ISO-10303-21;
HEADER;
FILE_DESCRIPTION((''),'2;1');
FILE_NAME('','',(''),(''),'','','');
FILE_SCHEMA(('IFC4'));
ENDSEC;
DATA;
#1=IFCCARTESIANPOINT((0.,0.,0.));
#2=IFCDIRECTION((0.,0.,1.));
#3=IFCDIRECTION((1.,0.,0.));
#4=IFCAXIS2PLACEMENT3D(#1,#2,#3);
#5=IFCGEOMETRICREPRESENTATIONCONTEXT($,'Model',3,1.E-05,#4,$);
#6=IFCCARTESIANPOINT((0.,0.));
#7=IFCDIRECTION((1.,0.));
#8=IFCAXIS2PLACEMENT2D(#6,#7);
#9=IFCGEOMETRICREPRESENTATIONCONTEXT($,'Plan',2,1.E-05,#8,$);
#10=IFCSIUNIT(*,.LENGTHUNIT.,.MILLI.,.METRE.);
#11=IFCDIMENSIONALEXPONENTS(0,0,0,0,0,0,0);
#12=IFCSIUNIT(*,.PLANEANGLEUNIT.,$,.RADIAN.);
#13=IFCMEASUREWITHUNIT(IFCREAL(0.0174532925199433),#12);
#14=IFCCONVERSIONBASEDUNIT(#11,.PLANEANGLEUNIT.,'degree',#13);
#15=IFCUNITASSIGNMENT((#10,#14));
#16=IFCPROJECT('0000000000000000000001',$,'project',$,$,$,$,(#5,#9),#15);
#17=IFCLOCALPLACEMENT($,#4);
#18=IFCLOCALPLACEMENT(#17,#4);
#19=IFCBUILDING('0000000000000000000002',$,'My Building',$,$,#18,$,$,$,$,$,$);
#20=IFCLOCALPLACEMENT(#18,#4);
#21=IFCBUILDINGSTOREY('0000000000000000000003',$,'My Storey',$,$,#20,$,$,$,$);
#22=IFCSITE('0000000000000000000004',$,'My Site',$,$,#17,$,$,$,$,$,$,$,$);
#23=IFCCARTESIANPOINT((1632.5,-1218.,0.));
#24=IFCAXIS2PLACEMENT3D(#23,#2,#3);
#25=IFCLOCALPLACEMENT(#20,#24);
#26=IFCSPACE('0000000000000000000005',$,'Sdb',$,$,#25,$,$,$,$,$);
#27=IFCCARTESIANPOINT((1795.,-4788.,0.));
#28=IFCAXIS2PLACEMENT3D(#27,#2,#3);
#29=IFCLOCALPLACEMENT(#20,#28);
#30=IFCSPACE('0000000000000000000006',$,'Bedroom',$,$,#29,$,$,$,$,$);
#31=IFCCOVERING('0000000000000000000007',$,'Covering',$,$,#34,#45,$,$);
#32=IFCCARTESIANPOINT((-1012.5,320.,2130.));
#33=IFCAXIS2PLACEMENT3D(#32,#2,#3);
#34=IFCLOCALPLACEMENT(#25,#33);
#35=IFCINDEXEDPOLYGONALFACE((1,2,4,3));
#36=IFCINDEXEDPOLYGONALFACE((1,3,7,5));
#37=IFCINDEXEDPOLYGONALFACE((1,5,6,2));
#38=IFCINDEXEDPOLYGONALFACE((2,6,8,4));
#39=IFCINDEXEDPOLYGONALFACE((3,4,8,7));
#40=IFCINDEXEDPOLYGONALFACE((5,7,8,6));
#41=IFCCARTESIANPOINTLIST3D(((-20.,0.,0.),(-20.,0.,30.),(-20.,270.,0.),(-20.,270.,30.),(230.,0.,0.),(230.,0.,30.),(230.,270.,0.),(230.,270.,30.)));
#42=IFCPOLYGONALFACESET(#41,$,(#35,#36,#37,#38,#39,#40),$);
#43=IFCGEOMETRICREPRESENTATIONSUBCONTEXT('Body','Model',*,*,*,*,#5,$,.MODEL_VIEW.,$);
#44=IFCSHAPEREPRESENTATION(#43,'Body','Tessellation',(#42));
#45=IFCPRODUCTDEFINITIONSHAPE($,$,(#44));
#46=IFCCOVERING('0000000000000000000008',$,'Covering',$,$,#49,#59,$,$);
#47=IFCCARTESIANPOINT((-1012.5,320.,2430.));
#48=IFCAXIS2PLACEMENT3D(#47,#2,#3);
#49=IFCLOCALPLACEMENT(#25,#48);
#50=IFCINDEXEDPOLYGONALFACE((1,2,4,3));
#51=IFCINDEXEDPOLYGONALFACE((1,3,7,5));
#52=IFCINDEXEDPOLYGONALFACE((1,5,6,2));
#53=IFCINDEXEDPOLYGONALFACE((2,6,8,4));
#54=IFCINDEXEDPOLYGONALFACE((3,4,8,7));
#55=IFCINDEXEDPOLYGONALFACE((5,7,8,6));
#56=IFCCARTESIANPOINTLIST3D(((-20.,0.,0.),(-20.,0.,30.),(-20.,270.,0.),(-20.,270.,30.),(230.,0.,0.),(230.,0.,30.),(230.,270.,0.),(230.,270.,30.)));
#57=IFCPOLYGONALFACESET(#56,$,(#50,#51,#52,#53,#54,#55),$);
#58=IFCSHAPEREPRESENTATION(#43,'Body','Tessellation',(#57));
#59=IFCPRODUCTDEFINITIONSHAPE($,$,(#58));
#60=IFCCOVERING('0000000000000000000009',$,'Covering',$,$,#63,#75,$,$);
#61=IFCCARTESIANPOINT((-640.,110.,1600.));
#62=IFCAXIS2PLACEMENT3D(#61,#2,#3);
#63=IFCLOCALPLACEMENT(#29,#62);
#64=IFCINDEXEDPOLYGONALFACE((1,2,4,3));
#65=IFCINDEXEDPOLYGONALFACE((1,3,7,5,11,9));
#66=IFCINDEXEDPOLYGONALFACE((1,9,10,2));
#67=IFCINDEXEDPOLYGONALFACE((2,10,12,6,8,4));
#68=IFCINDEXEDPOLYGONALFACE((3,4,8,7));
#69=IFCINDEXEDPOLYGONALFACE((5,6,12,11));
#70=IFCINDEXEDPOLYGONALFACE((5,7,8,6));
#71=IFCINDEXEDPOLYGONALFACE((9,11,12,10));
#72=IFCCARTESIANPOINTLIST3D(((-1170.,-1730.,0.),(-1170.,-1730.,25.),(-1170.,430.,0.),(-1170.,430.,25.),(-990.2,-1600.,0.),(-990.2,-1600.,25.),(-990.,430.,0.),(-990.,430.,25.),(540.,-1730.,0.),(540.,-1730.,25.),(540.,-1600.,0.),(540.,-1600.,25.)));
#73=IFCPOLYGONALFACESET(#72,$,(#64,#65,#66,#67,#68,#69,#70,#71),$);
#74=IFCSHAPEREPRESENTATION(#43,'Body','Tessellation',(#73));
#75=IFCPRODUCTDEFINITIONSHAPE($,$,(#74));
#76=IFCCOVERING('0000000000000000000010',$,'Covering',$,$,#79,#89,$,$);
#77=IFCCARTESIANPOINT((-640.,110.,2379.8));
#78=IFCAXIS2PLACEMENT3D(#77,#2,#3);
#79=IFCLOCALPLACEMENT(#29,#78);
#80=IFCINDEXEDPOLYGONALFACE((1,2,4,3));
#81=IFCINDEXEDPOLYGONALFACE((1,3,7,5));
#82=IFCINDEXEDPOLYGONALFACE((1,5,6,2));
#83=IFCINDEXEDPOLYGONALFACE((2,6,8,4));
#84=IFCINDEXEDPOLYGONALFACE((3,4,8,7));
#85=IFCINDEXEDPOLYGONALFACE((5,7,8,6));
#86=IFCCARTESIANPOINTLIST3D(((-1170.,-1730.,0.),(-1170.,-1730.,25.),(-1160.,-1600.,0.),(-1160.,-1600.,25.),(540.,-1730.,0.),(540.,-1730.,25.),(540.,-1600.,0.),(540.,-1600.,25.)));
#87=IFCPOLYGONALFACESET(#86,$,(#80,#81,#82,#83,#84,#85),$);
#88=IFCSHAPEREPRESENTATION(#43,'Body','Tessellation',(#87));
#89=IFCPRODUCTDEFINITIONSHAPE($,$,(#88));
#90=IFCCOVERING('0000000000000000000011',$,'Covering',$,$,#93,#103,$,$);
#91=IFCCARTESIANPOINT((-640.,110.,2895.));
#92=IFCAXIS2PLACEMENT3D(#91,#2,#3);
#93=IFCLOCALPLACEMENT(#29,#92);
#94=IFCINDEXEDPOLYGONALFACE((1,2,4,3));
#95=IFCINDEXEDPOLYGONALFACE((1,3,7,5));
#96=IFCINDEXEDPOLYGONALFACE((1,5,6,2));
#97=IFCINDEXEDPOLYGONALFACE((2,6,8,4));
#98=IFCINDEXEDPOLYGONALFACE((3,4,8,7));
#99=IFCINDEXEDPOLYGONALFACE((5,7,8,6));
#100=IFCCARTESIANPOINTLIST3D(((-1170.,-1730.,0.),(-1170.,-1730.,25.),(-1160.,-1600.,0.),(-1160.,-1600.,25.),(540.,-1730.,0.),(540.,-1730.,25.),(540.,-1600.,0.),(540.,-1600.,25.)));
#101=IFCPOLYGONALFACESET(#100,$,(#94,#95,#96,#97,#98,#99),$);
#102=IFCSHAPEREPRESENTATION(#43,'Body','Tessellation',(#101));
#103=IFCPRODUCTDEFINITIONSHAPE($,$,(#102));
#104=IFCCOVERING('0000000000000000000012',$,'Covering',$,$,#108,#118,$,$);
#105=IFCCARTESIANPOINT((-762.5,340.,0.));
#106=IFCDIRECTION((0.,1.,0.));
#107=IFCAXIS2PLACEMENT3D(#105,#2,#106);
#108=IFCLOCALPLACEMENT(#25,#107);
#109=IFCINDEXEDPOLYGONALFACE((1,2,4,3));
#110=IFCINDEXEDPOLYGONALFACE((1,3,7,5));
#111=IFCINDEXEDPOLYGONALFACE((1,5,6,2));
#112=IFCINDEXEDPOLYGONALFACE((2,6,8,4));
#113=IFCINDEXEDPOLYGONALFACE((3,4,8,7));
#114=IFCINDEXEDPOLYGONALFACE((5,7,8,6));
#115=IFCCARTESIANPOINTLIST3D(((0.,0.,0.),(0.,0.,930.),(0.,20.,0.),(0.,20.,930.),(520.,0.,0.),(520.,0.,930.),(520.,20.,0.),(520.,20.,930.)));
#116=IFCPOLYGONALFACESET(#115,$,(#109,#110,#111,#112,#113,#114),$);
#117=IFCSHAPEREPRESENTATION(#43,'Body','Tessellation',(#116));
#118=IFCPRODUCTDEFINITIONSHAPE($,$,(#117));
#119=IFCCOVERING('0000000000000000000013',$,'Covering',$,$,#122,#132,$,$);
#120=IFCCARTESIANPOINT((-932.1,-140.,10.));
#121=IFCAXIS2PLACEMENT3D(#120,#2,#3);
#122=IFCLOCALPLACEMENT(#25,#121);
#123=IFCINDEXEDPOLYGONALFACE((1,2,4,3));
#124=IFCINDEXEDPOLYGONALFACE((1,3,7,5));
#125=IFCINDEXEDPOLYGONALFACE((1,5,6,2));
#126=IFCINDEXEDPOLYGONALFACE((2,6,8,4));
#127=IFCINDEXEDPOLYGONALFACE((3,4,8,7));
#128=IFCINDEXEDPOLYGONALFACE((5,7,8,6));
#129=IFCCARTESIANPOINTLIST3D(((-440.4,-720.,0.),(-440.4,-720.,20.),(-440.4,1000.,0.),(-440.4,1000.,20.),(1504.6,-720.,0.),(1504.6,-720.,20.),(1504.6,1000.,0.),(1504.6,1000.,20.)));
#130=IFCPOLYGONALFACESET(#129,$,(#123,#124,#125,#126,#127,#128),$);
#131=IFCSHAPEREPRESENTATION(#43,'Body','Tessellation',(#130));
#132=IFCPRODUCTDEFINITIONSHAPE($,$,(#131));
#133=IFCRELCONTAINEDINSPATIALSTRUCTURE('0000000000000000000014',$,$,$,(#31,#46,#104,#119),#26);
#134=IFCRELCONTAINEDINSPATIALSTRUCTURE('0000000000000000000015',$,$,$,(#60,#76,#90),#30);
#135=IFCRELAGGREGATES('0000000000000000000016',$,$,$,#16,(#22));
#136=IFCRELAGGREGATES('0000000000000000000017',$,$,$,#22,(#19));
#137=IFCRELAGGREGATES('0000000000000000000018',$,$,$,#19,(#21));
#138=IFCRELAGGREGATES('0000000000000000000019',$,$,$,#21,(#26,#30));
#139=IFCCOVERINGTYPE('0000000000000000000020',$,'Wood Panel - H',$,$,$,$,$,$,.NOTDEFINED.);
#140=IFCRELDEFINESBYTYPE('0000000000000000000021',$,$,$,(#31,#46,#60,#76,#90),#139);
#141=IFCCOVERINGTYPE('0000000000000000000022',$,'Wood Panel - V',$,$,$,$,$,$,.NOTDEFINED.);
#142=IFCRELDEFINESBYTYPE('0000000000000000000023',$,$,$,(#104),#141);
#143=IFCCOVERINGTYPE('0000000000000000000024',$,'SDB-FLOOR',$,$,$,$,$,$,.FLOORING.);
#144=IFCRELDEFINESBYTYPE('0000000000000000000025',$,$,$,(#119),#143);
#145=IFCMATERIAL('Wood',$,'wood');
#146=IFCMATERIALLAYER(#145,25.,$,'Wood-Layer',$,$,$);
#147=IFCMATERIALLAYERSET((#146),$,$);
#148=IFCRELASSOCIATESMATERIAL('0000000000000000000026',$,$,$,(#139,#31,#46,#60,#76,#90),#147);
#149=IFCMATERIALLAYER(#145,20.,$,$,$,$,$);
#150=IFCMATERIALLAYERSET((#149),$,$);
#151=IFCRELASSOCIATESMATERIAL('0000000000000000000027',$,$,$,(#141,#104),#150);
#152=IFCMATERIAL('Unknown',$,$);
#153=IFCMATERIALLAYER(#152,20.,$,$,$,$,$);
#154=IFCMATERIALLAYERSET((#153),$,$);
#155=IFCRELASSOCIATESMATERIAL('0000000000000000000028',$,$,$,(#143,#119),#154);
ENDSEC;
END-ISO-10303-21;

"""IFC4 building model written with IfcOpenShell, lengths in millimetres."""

from ifc_helpers import new_model, entity, si_unit, converted_unit, frame, origin_with_axes, origin_2d_with_axis, place, context, subcontext, project, spatial, line, indexed_curve, outline, extrude, clip, halfspace, material, layer, layer_set, layer_usage, type_object, element, save


model = new_model("IFC4")

# Units and contexts
model_context = context("Model", 3, precision=1e-05, world=origin_with_axes())
plan_context = context("Plan", 2, precision=1e-05, world=origin_2d_with_axis())
body_context = subcontext(model_context, "Body", "Model", "MODEL_VIEW")
ifc_project = project(units=[si_unit("LENGTHUNIT", "METRE", prefix="MILLI"), converted_unit("PLANEANGLEUNIT", "degree", entity("IfcReal", 0.0174532925199433), si_unit("PLANEANGLEUNIT", "RADIAN"), dimensions=[0, 0, 0, 0, 0, 0, 0])], contexts=[model_context, plan_context])

# Site, building, storey, space
site_placement = place(None, origin_with_axes())
site = spatial("IfcSite", under=ifc_project, at=site_placement, Name="My Site")
building_placement = place(site_placement, origin_with_axes())
building = spatial("IfcBuilding", under=site, at=building_placement, Name="My Building")
storey_placement = place(building_placement, origin_with_axes())
storey = spatial("IfcBuildingStorey", under=building, at=storey_placement, Name="My Storey")
space_1_placement = place(storey_placement, frame((1632.5, -1218.0, 0.0), z_axis=(0.0, 0.0, 1.0), x_axis=(1.0, 0.0, 0.0)))
space_1 = spatial("IfcSpace", under=storey, at=space_1_placement, Name="Sdb")

# Shared definitions
ifc_material_1 = material(Name="Unknown")

# Shared definitions
space_2_placement = place(storey_placement, frame((1795.0, -4788.0, 0.0), z_axis=(0.0, 0.0, 1.0), x_axis=(1.0, 0.0, 0.0)))
space_2 = spatial("IfcSpace", under=storey, at=space_2_placement, Name="Bedroom")

# Coverings
ifc_material_2 = material(Name="Wood", Category="wood")
ifc_layer_1 = layer(ifc_material_2, 25.0, Name="Wood-Layer")
ifc_layer_set_1 = layer_set([ifc_layer_1])
covering_type_1 = type_object("IfcCoveringType", Name="Wood Panel - H", PredefinedType="NOTDEFINED", material=ifc_layer_set_1)
ifc_layer_usage_1 = layer_usage(ifc_layer_set_1, "AXIS3", "POSITIVE", 0.0)
covering_1_placement = place(space_1_placement, frame((-1012.5, 320.0, 2130.0), z_axis=(0.0, 0.0, 1.0), x_axis=(1.0, 0.0, 0.0)))
element("IfcCovering", 1, at=covering_1_placement, inside=space_1, type_object=covering_type_1, material=ifc_layer_usage_1, Name="Covering", context=body_context, shape_type="SweptSolid", body=[
    extrude(outline(indexed_curve([(-20.0, 0.0), (-20.0, 270.0), (230.0, 270.0), (230.0, 0.0)], segments=[line(4, 1), line(1, 2), line(2, 3), line(3, 4)], self_intersect=False)), None, (0.0, 0.0, 1.0), 30.0),
])
ifc_layer_usage_2 = layer_usage(ifc_layer_set_1, "AXIS3", "POSITIVE", 0.0)
covering_2_placement = place(space_1_placement, frame((-1012.5, 320.0, 2430.0), z_axis=(0.0, 0.0, 1.0), x_axis=(1.0, 0.0, 0.0)))
element("IfcCovering", 2, at=covering_2_placement, inside=space_1, type_object=covering_type_1, material=ifc_layer_usage_2, Name="Covering", context=body_context, shape_type="SweptSolid", body=[
    extrude(outline(indexed_curve([(-20.0, 0.0), (-20.0, 270.0), (230.0, 270.0), (230.0, 0.0)], segments=[line(4, 1), line(1, 2), line(2, 3), line(3, 4)], self_intersect=False)), None, (0.0, 0.0, 1.0), 30.0),
])
ifc_layer_usage_3 = layer_usage(ifc_layer_set_1, "AXIS3", "POSITIVE", 0.0)
covering_3_placement = place(space_2_placement, frame((-640.0, 110.0, 1600.0), z_axis=(0.0, 0.0, 1.0), x_axis=(1.0, 0.0, 0.0)))
element("IfcCovering", 3, at=covering_3_placement, inside=space_2, type_object=covering_type_1, material=ifc_layer_usage_3, Name="Covering", context=body_context, shape_type="SweptSolid", body=[
    extrude(outline(indexed_curve([(540.0, -1600.0), (540.0, -1730.0), (-1170.0, -1730.0), (-1170.0, 430.0), (-990.0, 430.0), (-990.2, -1600.0)], segments=[line(6, 5), line(5, 4), line(4, 3), line(3, 2), line(2, 1), line(1, 6)], self_intersect=False)), None, (0.0, 0.0, 1.0), 25.0),
])
ifc_layer_usage_4 = layer_usage(ifc_layer_set_1, "AXIS3", "POSITIVE", 0.0)
covering_4_placement = place(space_2_placement, frame((-640.0, 110.0, 2379.8), z_axis=(0.0, 0.0, 1.0), x_axis=(1.0, 0.0, 0.0)))
element("IfcCovering", 4, at=covering_4_placement, inside=space_2, type_object=covering_type_1, material=ifc_layer_usage_4, Name="Covering", context=body_context, shape_type="SweptSolid", body=[
    extrude(outline(indexed_curve([(-1160.0, -1600.0), (-1170.0, -1730.0), (540.0, -1730.0), (540.0, -1600.0)], segments=[line(3, 2), line(2, 1), line(1, 4), line(4, 3)], self_intersect=False)), None, (0.0, 0.0, 1.0), 25.0),
])
ifc_layer_usage_5 = layer_usage(ifc_layer_set_1, "AXIS3", "POSITIVE", 0.0)
covering_5_placement = place(space_2_placement, frame((-640.0, 110.0, 2895.0), z_axis=(0.0, 0.0, 1.0), x_axis=(1.0, 0.0, 0.0)))
element("IfcCovering", 5, at=covering_5_placement, inside=space_2, type_object=covering_type_1, material=ifc_layer_usage_5, Name="Covering", context=body_context, shape_type="SweptSolid", body=[
    extrude(outline(indexed_curve([(-1160.0, -1600.0), (-1170.0, -1730.0), (540.0, -1730.0), (540.0, -1600.0)], segments=[line(3, 2), line(2, 1), line(1, 4), line(4, 3)], self_intersect=False)), None, (0.0, 0.0, 1.0), 25.0),
])
ifc_layer_2 = layer(ifc_material_2, 20.0)
ifc_layer_set_2 = layer_set([ifc_layer_2])
ifc_layer_usage_6 = layer_usage(ifc_layer_set_2, "AXIS2", "POSITIVE", 0.0)
covering_type_2 = type_object("IfcCoveringType", Name="Wood Panel - V", PredefinedType="NOTDEFINED", material=ifc_layer_set_2)
covering_6_placement = place(space_1_placement, frame((-762.5, 340.0, 0.0), z_axis=(0.0, 0.0, 1.0), x_axis=(0.0, 1.0, 0.0)))
element("IfcCovering", 6, at=covering_6_placement, inside=space_1, type_object=covering_type_2, material=ifc_layer_usage_6, Name="Covering", context=body_context, shape_type="Clipping", body=[
    clip(extrude(outline(indexed_curve([(0.0, 0.0), (0.0, 20.0), (520.0, 20.0), (520.0, 0.0), (0.0, 0.0)], self_intersect=False)), origin_with_axes(), (0.0, 0.0, 1.0), 930.0), halfspace(frame((0.0, 0.0, 930.0), z_axis=(0.0, 0.0, 1.0), x_axis=(-1.0, 0.0, 0.0)), False)),
])
ifc_layer_3 = layer(ifc_material_1, 20.0)
ifc_layer_set_3 = layer_set([ifc_layer_3])
ifc_layer_usage_7 = layer_usage(ifc_layer_set_3, "AXIS3", "POSITIVE", 0.0)
covering_type_3 = type_object("IfcCoveringType", Name="SDB-FLOOR", PredefinedType="FLOORING", material=ifc_layer_set_3)
covering_7_placement = place(space_1_placement, frame((-932.1, -140.0, 10.0), z_axis=(0.0, 0.0, 1.0), x_axis=(1.0, 0.0, 0.0)))
element("IfcCovering", 7, at=covering_7_placement, inside=space_1, type_object=covering_type_3, material=ifc_layer_usage_7, Name="Covering", context=body_context, shape_type="SweptSolid", body=[
    extrude(outline(indexed_curve([(-440.4, 1000.0), (-440.4, -720.0), (1504.6, -720.0), (1504.6, 1000.0)], segments=[line(4, 1), line(1, 2), line(2, 3), line(3, 4)], self_intersect=False)), None, (0.0, 0.0, 1.0), 20.0),
])

save(model, "model.ifc")
